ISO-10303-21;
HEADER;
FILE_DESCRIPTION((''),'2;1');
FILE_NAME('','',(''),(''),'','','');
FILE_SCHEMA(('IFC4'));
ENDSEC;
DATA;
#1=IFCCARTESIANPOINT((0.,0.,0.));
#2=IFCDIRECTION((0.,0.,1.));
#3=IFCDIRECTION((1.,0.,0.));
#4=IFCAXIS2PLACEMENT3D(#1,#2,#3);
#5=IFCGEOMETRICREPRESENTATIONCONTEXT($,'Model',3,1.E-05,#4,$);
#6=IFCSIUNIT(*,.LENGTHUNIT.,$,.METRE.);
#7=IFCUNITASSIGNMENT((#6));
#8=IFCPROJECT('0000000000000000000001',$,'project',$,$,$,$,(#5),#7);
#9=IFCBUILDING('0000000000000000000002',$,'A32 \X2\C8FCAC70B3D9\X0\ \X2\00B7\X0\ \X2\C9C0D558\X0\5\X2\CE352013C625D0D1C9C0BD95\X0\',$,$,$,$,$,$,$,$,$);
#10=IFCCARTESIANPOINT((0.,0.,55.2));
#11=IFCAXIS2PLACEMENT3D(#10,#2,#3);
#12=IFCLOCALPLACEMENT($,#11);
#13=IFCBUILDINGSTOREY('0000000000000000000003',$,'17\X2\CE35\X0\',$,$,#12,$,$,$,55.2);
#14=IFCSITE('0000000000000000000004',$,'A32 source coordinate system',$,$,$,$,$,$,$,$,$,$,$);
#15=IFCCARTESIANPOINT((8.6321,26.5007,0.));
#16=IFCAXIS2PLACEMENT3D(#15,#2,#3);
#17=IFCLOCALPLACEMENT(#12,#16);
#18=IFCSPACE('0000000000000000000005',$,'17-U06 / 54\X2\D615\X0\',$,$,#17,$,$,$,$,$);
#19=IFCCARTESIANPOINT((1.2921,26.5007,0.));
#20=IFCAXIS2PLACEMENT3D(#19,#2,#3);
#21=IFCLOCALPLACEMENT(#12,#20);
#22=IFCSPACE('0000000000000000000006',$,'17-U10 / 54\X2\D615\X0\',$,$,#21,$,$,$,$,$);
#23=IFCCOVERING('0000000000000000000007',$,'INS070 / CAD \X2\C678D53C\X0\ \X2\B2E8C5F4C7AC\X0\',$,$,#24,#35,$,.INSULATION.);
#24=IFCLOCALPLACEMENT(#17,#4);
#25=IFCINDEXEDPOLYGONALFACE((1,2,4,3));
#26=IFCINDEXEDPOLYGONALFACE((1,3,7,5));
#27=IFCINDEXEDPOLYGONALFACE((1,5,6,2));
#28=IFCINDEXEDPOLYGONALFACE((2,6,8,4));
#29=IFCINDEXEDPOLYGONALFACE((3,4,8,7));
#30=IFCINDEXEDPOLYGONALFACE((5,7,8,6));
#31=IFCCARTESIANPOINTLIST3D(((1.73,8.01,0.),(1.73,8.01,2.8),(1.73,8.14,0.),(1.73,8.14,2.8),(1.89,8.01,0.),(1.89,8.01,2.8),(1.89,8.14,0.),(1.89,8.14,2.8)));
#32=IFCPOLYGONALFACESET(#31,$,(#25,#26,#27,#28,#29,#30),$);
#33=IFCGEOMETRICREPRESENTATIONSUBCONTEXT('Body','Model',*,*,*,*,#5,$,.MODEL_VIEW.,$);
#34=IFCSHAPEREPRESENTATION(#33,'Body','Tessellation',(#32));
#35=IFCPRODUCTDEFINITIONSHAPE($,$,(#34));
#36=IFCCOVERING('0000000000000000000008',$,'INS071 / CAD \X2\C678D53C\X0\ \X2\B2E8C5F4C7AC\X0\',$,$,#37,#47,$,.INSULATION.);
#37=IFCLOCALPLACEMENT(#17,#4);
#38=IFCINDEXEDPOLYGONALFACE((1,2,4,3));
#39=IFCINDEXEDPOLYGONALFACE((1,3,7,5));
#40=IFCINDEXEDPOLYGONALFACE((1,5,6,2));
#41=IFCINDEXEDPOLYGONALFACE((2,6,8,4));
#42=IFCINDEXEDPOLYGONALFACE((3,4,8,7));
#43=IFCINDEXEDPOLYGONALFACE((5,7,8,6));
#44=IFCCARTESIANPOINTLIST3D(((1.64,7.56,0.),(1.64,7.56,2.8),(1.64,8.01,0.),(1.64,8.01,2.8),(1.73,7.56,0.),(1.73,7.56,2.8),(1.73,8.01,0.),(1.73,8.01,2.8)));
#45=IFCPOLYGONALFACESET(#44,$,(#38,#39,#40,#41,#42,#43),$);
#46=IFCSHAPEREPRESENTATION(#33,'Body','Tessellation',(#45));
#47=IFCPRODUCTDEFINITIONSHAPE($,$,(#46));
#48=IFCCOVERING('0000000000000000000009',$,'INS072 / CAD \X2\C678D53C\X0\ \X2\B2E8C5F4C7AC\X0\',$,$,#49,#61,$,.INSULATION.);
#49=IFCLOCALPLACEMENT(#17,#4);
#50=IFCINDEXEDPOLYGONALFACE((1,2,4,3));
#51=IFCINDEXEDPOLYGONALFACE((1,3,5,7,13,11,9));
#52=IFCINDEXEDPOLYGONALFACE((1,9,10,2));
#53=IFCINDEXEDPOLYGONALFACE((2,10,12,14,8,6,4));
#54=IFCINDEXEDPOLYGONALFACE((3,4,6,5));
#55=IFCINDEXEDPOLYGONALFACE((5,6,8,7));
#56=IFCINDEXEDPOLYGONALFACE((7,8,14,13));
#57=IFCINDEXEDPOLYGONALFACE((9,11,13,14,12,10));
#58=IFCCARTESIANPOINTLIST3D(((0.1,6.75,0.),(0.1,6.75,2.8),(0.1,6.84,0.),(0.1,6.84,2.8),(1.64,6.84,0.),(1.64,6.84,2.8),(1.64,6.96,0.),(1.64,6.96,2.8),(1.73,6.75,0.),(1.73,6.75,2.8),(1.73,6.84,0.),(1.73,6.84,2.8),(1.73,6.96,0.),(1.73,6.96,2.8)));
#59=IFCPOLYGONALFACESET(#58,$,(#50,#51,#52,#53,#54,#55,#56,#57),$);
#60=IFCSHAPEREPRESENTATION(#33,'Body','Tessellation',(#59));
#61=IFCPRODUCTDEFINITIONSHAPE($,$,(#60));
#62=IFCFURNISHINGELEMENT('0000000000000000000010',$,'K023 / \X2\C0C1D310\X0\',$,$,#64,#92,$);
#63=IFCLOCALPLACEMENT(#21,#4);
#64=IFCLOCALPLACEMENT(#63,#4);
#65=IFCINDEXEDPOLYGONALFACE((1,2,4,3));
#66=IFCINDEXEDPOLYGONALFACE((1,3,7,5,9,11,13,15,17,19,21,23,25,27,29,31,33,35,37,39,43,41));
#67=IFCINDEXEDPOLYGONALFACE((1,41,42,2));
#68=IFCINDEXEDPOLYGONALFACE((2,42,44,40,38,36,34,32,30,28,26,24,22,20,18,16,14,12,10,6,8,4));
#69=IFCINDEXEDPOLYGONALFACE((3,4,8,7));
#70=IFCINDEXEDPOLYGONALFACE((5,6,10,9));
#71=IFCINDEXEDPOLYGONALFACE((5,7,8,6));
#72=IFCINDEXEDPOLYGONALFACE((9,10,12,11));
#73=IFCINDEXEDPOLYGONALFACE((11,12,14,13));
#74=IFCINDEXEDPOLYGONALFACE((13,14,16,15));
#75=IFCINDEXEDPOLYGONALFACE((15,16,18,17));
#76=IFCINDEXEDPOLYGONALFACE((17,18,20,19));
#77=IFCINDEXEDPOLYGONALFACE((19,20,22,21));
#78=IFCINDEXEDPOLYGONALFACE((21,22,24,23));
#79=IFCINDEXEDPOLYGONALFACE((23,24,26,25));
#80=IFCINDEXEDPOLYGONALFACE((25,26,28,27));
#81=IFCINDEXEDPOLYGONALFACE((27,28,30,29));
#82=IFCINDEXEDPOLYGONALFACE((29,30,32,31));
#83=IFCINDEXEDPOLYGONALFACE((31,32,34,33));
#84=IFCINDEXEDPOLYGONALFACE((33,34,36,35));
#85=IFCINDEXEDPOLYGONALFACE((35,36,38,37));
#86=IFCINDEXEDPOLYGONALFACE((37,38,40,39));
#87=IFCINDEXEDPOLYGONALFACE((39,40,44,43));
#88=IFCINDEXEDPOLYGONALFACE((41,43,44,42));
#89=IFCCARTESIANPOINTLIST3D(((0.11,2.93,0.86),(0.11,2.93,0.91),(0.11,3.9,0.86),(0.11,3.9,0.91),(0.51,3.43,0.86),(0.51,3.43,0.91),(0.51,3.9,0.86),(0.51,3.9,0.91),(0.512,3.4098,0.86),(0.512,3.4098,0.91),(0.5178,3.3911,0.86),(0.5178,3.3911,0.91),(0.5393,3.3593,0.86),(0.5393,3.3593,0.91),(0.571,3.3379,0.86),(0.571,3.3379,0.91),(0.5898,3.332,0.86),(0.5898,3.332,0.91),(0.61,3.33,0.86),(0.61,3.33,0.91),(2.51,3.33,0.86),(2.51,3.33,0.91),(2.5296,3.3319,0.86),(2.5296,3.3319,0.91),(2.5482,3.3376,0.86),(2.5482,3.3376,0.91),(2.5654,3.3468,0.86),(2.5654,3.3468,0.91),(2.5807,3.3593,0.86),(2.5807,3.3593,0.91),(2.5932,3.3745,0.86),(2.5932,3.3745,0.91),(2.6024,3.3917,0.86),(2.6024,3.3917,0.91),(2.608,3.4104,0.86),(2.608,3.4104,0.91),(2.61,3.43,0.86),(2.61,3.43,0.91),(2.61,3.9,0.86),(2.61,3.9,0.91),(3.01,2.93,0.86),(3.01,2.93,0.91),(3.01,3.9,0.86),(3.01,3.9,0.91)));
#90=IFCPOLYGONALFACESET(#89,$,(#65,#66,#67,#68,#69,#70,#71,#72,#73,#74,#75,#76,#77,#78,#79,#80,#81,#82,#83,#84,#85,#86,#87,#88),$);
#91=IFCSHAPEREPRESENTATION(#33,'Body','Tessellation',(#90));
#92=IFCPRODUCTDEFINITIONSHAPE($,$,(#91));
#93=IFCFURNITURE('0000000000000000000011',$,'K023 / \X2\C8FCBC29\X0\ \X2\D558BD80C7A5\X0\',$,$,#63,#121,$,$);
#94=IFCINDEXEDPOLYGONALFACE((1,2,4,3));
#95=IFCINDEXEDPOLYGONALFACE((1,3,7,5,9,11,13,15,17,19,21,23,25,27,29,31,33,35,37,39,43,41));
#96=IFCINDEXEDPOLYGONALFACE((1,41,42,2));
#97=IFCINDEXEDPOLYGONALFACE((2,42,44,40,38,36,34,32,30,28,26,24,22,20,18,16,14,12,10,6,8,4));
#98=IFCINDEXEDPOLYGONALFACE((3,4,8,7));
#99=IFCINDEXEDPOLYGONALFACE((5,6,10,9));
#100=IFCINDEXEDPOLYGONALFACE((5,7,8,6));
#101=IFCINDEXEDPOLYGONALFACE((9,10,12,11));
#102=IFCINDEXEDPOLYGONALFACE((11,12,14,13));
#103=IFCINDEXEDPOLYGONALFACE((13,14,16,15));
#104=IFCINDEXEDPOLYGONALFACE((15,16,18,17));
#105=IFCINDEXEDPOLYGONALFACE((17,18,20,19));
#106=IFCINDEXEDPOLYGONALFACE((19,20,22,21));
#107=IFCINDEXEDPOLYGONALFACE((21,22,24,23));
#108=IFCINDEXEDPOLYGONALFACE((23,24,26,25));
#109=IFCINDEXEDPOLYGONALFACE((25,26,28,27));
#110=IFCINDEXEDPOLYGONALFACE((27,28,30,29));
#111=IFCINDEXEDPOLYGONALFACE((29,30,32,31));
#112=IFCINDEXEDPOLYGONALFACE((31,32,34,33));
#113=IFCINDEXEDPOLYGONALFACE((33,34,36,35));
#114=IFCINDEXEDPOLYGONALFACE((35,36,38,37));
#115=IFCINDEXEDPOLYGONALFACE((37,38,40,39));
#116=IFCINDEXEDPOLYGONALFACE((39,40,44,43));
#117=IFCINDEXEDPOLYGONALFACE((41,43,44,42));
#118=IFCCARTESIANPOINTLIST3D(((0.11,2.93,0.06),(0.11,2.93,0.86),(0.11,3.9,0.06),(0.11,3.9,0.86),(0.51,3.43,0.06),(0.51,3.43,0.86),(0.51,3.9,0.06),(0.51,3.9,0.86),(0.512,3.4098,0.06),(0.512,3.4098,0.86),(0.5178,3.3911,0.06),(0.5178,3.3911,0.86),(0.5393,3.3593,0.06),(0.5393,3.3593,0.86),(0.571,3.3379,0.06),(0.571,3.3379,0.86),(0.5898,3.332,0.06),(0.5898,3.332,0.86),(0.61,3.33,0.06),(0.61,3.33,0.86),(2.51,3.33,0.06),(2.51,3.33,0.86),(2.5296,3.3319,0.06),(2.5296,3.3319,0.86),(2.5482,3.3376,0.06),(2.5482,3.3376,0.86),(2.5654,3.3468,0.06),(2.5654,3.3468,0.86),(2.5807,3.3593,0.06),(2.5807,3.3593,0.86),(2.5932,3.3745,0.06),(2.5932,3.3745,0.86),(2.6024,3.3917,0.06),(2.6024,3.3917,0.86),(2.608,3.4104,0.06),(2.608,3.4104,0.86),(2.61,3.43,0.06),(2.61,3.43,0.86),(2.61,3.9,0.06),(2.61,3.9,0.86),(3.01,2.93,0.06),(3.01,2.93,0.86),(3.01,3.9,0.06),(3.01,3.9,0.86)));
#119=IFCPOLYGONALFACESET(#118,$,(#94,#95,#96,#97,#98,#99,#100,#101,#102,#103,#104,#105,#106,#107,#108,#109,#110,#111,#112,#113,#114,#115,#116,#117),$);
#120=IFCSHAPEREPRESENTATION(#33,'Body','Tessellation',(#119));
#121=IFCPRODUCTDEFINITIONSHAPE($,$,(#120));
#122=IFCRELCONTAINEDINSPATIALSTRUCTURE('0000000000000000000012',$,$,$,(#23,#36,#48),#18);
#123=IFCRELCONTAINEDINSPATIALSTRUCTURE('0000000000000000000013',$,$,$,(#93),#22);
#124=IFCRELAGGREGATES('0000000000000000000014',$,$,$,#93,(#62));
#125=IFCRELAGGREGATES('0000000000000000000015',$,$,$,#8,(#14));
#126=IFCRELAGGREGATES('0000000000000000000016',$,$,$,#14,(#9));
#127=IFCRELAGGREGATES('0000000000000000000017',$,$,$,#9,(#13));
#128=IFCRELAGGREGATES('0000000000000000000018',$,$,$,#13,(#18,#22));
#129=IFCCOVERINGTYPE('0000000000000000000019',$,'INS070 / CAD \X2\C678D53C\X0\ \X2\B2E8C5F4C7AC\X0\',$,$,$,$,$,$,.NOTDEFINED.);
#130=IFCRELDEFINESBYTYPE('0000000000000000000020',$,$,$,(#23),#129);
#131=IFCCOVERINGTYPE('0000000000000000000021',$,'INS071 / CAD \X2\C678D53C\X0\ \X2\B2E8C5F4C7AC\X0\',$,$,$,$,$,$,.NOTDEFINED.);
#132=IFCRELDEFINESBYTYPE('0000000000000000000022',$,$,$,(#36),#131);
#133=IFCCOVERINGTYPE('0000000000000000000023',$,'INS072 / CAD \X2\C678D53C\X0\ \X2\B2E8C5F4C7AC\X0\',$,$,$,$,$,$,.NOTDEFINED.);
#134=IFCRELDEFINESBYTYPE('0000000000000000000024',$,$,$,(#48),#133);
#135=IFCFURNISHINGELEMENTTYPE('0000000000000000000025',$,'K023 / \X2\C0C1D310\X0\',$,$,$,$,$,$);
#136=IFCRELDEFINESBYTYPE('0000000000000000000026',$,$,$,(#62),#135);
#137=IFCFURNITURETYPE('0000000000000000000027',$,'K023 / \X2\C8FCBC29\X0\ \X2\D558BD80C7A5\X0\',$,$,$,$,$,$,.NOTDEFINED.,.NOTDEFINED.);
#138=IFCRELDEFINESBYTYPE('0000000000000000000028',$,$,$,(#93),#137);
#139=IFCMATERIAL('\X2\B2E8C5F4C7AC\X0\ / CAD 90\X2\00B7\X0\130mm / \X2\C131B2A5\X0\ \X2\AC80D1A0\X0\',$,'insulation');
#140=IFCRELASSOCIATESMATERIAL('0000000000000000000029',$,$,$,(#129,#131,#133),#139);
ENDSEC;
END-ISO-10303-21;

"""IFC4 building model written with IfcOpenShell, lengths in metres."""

from ifc_helpers import new_model, si_unit, frame, origin, origin_with_axes, place, context, subcontext, project, spatial, polyline, outline, extrude, source, transform, mapped, material, type_object, type_shapes, element, aggregate, save


model = new_model("IFC4")

# Units and contexts
model_context = context("Model", 3, precision=1e-05, world=origin_with_axes())
body_context = subcontext(model_context, "Body", "Model", "MODEL_VIEW")
ifc_project = project(units=[si_unit("LENGTHUNIT", "METRE")], contexts=[model_context])

# Site, building, storey, space
storey_placement = place(None, frame((0.0, 0.0, 55.2), z_axis=(0.0, 0.0, 1.0), x_axis=(1.0, 0.0, 0.0)))
space_1_placement = place(storey_placement, frame((8.6321, 26.5007, 0.0), z_axis=(0.0, 0.0, 1.0), x_axis=(1.0, 0.0, 0.0)))
site = spatial("IfcSite", under=ifc_project, Name="A32 source coordinate system")
building = spatial("IfcBuilding", under=site, Name="A32 주거동 · 지하5층–옥탑지붕")
storey = spatial("IfcBuildingStorey", under=building, at=storey_placement, Name="17층", Elevation=55.2)
space_1 = spatial("IfcSpace", under=storey, at=space_1_placement, Name="17-U06 / 54형")

# Coverings
ifc_material = material(Name="단열재 / CAD 90·130mm / 성능 검토", Category="insulation")
covering_type_1 = type_object("IfcCoveringType", Name="INS070 / CAD 외피 단열재", PredefinedType="NOTDEFINED", material=ifc_material)
shared_shape_1 = source(origin(), body_context, "Body", "SweptSolid", [
    extrude(outline(polyline([(1.73, 8.14), (1.89, 8.14), (1.89, 8.01), (1.73, 8.01), (1.73, 8.14)])), origin(), (0.0, 0.0, 1.0), 2.8),
])
type_shapes(covering_type_1, [shared_shape_1])
covering_1_placement = place(space_1_placement, origin_with_axes())
element("IfcCovering", 1, at=covering_1_placement, inside=space_1, type_object=covering_type_1, Name="INS070 / CAD 외피 단열재", PredefinedType="INSULATION", context=body_context, shape_type="MappedRepresentation", body=[
    mapped(shared_shape_1, transform((0.0, 0.0, 0.0), scale=1.0)),
])
covering_type_2 = type_object("IfcCoveringType", Name="INS071 / CAD 외피 단열재", PredefinedType="NOTDEFINED", material=ifc_material)
shared_shape_2 = source(origin(), body_context, "Body", "SweptSolid", [
    extrude(outline(polyline([(1.73, 7.56), (1.64, 7.56), (1.64, 8.01), (1.73, 8.01), (1.73, 7.56)])), origin(), (0.0, 0.0, 1.0), 2.8),
])
type_shapes(covering_type_2, [shared_shape_2])
covering_2_placement = place(space_1_placement, origin_with_axes())
element("IfcCovering", 2, at=covering_2_placement, inside=space_1, type_object=covering_type_2, Name="INS071 / CAD 외피 단열재", PredefinedType="INSULATION", context=body_context, shape_type="MappedRepresentation", body=[
    mapped(shared_shape_2, transform((0.0, 0.0, 0.0), scale=1.0)),
])
covering_type_3 = type_object("IfcCoveringType", Name="INS072 / CAD 외피 단열재", PredefinedType="NOTDEFINED", material=ifc_material)
shared_shape_3 = source(origin(), body_context, "Body", "SweptSolid", [
    extrude(outline(polyline([(1.64, 6.84), (1.64, 6.96), (1.73, 6.96), (1.73, 6.84), (1.73, 6.75), (0.1, 6.75), (0.1, 6.84), (1.64, 6.84)])), origin(), (0.0, 0.0, 1.0), 2.8),
])
type_shapes(covering_type_3, [shared_shape_3])
covering_3_placement = place(space_1_placement, origin_with_axes())
element("IfcCovering", 3, at=covering_3_placement, inside=space_1, type_object=covering_type_3, Name="INS072 / CAD 외피 단열재", PredefinedType="INSULATION", context=body_context, shape_type="MappedRepresentation", body=[
    mapped(shared_shape_3, transform((0.0, 0.0, 0.0), scale=1.0)),
])

# Shared definitions
space_2_placement = place(storey_placement, frame((1.2921, 26.5007, 0.0), z_axis=(0.0, 0.0, 1.0), x_axis=(1.0, 0.0, 0.0)))

# Furnishing element
furnishing_element_type_1 = type_object("IfcFurnishingElementType", Name="K023 / 상판")
shared_shape_4 = source(origin(), body_context, "Body", "SweptSolid", [
    extrude(outline(polyline([(0.51, 3.43), (0.512, 3.4098), (0.5178, 3.3911), (0.5393, 3.3593), (0.571, 3.3379), (0.5898, 3.332), (0.61, 3.33), (2.51, 3.33), (2.5296, 3.3319), (2.5482, 3.3376), (2.5654, 3.3468), (2.5807, 3.3593), (2.5932, 3.3745), (2.6024, 3.3917), (2.608, 3.4104), (2.61, 3.43), (2.61, 3.9), (3.01, 3.9), (3.01, 2.93), (0.11, 2.93), (0.11, 3.9), (0.51, 3.9), (0.51, 3.43)])), frame((0.0, 0.0, 0.86)), (0.0, 0.0, 1.0), 0.05),
])
type_shapes(furnishing_element_type_1, [shared_shape_4])
furniture_1_placement = place(space_2_placement, origin_with_axes())
furnishing_1_placement = place(furniture_1_placement, origin_with_axes())
furnishing_1 = element("IfcFurnishingElement", 4, at=furnishing_1_placement, type_object=furnishing_element_type_1, Name="K023 / 상판", context=body_context, shape_type="MappedRepresentation", body=[
    mapped(shared_shape_4, transform((0.0, 0.0, 0.0), scale=1.0)),
])

# Shared definitions
space_2 = spatial("IfcSpace", under=storey, at=space_2_placement, Name="17-U10 / 54형")

# Furniture
furniture_type_1 = type_object("IfcFurnitureType", Name="K023 / 주방 하부장", AssemblyPlace="NOTDEFINED", PredefinedType="NOTDEFINED")
shared_shape_5 = source(origin(), body_context, "Body", "SweptSolid", [
    extrude(outline(polyline([(0.51, 3.9), (0.51, 3.43), (0.512, 3.4098), (0.5178, 3.3911), (0.5393, 3.3593), (0.571, 3.3379), (0.5898, 3.332), (0.61, 3.33), (2.51, 3.33), (2.5296, 3.3319), (2.5482, 3.3376), (2.5654, 3.3468), (2.5807, 3.3593), (2.5932, 3.3745), (2.6024, 3.3917), (2.608, 3.4104), (2.61, 3.43), (2.61, 3.9), (3.01, 3.9), (3.01, 2.93), (0.11, 2.93), (0.11, 3.9), (0.51, 3.9)])), frame((0.0, 0.0, 0.06)), (0.0, 0.0, 1.0), 0.8),
])
type_shapes(furniture_type_1, [shared_shape_5])
furniture_1 = element("IfcFurniture", 5, at=furniture_1_placement, inside=space_2, type_object=furniture_type_1, Name="K023 / 주방 하부장", context=body_context, shape_type="MappedRepresentation", body=[
    mapped(shared_shape_5, transform((0.0, 0.0, 0.0), scale=1.0)),
])
aggregate(furniture_1, [furnishing_1])

save(model, "model.ifc")
